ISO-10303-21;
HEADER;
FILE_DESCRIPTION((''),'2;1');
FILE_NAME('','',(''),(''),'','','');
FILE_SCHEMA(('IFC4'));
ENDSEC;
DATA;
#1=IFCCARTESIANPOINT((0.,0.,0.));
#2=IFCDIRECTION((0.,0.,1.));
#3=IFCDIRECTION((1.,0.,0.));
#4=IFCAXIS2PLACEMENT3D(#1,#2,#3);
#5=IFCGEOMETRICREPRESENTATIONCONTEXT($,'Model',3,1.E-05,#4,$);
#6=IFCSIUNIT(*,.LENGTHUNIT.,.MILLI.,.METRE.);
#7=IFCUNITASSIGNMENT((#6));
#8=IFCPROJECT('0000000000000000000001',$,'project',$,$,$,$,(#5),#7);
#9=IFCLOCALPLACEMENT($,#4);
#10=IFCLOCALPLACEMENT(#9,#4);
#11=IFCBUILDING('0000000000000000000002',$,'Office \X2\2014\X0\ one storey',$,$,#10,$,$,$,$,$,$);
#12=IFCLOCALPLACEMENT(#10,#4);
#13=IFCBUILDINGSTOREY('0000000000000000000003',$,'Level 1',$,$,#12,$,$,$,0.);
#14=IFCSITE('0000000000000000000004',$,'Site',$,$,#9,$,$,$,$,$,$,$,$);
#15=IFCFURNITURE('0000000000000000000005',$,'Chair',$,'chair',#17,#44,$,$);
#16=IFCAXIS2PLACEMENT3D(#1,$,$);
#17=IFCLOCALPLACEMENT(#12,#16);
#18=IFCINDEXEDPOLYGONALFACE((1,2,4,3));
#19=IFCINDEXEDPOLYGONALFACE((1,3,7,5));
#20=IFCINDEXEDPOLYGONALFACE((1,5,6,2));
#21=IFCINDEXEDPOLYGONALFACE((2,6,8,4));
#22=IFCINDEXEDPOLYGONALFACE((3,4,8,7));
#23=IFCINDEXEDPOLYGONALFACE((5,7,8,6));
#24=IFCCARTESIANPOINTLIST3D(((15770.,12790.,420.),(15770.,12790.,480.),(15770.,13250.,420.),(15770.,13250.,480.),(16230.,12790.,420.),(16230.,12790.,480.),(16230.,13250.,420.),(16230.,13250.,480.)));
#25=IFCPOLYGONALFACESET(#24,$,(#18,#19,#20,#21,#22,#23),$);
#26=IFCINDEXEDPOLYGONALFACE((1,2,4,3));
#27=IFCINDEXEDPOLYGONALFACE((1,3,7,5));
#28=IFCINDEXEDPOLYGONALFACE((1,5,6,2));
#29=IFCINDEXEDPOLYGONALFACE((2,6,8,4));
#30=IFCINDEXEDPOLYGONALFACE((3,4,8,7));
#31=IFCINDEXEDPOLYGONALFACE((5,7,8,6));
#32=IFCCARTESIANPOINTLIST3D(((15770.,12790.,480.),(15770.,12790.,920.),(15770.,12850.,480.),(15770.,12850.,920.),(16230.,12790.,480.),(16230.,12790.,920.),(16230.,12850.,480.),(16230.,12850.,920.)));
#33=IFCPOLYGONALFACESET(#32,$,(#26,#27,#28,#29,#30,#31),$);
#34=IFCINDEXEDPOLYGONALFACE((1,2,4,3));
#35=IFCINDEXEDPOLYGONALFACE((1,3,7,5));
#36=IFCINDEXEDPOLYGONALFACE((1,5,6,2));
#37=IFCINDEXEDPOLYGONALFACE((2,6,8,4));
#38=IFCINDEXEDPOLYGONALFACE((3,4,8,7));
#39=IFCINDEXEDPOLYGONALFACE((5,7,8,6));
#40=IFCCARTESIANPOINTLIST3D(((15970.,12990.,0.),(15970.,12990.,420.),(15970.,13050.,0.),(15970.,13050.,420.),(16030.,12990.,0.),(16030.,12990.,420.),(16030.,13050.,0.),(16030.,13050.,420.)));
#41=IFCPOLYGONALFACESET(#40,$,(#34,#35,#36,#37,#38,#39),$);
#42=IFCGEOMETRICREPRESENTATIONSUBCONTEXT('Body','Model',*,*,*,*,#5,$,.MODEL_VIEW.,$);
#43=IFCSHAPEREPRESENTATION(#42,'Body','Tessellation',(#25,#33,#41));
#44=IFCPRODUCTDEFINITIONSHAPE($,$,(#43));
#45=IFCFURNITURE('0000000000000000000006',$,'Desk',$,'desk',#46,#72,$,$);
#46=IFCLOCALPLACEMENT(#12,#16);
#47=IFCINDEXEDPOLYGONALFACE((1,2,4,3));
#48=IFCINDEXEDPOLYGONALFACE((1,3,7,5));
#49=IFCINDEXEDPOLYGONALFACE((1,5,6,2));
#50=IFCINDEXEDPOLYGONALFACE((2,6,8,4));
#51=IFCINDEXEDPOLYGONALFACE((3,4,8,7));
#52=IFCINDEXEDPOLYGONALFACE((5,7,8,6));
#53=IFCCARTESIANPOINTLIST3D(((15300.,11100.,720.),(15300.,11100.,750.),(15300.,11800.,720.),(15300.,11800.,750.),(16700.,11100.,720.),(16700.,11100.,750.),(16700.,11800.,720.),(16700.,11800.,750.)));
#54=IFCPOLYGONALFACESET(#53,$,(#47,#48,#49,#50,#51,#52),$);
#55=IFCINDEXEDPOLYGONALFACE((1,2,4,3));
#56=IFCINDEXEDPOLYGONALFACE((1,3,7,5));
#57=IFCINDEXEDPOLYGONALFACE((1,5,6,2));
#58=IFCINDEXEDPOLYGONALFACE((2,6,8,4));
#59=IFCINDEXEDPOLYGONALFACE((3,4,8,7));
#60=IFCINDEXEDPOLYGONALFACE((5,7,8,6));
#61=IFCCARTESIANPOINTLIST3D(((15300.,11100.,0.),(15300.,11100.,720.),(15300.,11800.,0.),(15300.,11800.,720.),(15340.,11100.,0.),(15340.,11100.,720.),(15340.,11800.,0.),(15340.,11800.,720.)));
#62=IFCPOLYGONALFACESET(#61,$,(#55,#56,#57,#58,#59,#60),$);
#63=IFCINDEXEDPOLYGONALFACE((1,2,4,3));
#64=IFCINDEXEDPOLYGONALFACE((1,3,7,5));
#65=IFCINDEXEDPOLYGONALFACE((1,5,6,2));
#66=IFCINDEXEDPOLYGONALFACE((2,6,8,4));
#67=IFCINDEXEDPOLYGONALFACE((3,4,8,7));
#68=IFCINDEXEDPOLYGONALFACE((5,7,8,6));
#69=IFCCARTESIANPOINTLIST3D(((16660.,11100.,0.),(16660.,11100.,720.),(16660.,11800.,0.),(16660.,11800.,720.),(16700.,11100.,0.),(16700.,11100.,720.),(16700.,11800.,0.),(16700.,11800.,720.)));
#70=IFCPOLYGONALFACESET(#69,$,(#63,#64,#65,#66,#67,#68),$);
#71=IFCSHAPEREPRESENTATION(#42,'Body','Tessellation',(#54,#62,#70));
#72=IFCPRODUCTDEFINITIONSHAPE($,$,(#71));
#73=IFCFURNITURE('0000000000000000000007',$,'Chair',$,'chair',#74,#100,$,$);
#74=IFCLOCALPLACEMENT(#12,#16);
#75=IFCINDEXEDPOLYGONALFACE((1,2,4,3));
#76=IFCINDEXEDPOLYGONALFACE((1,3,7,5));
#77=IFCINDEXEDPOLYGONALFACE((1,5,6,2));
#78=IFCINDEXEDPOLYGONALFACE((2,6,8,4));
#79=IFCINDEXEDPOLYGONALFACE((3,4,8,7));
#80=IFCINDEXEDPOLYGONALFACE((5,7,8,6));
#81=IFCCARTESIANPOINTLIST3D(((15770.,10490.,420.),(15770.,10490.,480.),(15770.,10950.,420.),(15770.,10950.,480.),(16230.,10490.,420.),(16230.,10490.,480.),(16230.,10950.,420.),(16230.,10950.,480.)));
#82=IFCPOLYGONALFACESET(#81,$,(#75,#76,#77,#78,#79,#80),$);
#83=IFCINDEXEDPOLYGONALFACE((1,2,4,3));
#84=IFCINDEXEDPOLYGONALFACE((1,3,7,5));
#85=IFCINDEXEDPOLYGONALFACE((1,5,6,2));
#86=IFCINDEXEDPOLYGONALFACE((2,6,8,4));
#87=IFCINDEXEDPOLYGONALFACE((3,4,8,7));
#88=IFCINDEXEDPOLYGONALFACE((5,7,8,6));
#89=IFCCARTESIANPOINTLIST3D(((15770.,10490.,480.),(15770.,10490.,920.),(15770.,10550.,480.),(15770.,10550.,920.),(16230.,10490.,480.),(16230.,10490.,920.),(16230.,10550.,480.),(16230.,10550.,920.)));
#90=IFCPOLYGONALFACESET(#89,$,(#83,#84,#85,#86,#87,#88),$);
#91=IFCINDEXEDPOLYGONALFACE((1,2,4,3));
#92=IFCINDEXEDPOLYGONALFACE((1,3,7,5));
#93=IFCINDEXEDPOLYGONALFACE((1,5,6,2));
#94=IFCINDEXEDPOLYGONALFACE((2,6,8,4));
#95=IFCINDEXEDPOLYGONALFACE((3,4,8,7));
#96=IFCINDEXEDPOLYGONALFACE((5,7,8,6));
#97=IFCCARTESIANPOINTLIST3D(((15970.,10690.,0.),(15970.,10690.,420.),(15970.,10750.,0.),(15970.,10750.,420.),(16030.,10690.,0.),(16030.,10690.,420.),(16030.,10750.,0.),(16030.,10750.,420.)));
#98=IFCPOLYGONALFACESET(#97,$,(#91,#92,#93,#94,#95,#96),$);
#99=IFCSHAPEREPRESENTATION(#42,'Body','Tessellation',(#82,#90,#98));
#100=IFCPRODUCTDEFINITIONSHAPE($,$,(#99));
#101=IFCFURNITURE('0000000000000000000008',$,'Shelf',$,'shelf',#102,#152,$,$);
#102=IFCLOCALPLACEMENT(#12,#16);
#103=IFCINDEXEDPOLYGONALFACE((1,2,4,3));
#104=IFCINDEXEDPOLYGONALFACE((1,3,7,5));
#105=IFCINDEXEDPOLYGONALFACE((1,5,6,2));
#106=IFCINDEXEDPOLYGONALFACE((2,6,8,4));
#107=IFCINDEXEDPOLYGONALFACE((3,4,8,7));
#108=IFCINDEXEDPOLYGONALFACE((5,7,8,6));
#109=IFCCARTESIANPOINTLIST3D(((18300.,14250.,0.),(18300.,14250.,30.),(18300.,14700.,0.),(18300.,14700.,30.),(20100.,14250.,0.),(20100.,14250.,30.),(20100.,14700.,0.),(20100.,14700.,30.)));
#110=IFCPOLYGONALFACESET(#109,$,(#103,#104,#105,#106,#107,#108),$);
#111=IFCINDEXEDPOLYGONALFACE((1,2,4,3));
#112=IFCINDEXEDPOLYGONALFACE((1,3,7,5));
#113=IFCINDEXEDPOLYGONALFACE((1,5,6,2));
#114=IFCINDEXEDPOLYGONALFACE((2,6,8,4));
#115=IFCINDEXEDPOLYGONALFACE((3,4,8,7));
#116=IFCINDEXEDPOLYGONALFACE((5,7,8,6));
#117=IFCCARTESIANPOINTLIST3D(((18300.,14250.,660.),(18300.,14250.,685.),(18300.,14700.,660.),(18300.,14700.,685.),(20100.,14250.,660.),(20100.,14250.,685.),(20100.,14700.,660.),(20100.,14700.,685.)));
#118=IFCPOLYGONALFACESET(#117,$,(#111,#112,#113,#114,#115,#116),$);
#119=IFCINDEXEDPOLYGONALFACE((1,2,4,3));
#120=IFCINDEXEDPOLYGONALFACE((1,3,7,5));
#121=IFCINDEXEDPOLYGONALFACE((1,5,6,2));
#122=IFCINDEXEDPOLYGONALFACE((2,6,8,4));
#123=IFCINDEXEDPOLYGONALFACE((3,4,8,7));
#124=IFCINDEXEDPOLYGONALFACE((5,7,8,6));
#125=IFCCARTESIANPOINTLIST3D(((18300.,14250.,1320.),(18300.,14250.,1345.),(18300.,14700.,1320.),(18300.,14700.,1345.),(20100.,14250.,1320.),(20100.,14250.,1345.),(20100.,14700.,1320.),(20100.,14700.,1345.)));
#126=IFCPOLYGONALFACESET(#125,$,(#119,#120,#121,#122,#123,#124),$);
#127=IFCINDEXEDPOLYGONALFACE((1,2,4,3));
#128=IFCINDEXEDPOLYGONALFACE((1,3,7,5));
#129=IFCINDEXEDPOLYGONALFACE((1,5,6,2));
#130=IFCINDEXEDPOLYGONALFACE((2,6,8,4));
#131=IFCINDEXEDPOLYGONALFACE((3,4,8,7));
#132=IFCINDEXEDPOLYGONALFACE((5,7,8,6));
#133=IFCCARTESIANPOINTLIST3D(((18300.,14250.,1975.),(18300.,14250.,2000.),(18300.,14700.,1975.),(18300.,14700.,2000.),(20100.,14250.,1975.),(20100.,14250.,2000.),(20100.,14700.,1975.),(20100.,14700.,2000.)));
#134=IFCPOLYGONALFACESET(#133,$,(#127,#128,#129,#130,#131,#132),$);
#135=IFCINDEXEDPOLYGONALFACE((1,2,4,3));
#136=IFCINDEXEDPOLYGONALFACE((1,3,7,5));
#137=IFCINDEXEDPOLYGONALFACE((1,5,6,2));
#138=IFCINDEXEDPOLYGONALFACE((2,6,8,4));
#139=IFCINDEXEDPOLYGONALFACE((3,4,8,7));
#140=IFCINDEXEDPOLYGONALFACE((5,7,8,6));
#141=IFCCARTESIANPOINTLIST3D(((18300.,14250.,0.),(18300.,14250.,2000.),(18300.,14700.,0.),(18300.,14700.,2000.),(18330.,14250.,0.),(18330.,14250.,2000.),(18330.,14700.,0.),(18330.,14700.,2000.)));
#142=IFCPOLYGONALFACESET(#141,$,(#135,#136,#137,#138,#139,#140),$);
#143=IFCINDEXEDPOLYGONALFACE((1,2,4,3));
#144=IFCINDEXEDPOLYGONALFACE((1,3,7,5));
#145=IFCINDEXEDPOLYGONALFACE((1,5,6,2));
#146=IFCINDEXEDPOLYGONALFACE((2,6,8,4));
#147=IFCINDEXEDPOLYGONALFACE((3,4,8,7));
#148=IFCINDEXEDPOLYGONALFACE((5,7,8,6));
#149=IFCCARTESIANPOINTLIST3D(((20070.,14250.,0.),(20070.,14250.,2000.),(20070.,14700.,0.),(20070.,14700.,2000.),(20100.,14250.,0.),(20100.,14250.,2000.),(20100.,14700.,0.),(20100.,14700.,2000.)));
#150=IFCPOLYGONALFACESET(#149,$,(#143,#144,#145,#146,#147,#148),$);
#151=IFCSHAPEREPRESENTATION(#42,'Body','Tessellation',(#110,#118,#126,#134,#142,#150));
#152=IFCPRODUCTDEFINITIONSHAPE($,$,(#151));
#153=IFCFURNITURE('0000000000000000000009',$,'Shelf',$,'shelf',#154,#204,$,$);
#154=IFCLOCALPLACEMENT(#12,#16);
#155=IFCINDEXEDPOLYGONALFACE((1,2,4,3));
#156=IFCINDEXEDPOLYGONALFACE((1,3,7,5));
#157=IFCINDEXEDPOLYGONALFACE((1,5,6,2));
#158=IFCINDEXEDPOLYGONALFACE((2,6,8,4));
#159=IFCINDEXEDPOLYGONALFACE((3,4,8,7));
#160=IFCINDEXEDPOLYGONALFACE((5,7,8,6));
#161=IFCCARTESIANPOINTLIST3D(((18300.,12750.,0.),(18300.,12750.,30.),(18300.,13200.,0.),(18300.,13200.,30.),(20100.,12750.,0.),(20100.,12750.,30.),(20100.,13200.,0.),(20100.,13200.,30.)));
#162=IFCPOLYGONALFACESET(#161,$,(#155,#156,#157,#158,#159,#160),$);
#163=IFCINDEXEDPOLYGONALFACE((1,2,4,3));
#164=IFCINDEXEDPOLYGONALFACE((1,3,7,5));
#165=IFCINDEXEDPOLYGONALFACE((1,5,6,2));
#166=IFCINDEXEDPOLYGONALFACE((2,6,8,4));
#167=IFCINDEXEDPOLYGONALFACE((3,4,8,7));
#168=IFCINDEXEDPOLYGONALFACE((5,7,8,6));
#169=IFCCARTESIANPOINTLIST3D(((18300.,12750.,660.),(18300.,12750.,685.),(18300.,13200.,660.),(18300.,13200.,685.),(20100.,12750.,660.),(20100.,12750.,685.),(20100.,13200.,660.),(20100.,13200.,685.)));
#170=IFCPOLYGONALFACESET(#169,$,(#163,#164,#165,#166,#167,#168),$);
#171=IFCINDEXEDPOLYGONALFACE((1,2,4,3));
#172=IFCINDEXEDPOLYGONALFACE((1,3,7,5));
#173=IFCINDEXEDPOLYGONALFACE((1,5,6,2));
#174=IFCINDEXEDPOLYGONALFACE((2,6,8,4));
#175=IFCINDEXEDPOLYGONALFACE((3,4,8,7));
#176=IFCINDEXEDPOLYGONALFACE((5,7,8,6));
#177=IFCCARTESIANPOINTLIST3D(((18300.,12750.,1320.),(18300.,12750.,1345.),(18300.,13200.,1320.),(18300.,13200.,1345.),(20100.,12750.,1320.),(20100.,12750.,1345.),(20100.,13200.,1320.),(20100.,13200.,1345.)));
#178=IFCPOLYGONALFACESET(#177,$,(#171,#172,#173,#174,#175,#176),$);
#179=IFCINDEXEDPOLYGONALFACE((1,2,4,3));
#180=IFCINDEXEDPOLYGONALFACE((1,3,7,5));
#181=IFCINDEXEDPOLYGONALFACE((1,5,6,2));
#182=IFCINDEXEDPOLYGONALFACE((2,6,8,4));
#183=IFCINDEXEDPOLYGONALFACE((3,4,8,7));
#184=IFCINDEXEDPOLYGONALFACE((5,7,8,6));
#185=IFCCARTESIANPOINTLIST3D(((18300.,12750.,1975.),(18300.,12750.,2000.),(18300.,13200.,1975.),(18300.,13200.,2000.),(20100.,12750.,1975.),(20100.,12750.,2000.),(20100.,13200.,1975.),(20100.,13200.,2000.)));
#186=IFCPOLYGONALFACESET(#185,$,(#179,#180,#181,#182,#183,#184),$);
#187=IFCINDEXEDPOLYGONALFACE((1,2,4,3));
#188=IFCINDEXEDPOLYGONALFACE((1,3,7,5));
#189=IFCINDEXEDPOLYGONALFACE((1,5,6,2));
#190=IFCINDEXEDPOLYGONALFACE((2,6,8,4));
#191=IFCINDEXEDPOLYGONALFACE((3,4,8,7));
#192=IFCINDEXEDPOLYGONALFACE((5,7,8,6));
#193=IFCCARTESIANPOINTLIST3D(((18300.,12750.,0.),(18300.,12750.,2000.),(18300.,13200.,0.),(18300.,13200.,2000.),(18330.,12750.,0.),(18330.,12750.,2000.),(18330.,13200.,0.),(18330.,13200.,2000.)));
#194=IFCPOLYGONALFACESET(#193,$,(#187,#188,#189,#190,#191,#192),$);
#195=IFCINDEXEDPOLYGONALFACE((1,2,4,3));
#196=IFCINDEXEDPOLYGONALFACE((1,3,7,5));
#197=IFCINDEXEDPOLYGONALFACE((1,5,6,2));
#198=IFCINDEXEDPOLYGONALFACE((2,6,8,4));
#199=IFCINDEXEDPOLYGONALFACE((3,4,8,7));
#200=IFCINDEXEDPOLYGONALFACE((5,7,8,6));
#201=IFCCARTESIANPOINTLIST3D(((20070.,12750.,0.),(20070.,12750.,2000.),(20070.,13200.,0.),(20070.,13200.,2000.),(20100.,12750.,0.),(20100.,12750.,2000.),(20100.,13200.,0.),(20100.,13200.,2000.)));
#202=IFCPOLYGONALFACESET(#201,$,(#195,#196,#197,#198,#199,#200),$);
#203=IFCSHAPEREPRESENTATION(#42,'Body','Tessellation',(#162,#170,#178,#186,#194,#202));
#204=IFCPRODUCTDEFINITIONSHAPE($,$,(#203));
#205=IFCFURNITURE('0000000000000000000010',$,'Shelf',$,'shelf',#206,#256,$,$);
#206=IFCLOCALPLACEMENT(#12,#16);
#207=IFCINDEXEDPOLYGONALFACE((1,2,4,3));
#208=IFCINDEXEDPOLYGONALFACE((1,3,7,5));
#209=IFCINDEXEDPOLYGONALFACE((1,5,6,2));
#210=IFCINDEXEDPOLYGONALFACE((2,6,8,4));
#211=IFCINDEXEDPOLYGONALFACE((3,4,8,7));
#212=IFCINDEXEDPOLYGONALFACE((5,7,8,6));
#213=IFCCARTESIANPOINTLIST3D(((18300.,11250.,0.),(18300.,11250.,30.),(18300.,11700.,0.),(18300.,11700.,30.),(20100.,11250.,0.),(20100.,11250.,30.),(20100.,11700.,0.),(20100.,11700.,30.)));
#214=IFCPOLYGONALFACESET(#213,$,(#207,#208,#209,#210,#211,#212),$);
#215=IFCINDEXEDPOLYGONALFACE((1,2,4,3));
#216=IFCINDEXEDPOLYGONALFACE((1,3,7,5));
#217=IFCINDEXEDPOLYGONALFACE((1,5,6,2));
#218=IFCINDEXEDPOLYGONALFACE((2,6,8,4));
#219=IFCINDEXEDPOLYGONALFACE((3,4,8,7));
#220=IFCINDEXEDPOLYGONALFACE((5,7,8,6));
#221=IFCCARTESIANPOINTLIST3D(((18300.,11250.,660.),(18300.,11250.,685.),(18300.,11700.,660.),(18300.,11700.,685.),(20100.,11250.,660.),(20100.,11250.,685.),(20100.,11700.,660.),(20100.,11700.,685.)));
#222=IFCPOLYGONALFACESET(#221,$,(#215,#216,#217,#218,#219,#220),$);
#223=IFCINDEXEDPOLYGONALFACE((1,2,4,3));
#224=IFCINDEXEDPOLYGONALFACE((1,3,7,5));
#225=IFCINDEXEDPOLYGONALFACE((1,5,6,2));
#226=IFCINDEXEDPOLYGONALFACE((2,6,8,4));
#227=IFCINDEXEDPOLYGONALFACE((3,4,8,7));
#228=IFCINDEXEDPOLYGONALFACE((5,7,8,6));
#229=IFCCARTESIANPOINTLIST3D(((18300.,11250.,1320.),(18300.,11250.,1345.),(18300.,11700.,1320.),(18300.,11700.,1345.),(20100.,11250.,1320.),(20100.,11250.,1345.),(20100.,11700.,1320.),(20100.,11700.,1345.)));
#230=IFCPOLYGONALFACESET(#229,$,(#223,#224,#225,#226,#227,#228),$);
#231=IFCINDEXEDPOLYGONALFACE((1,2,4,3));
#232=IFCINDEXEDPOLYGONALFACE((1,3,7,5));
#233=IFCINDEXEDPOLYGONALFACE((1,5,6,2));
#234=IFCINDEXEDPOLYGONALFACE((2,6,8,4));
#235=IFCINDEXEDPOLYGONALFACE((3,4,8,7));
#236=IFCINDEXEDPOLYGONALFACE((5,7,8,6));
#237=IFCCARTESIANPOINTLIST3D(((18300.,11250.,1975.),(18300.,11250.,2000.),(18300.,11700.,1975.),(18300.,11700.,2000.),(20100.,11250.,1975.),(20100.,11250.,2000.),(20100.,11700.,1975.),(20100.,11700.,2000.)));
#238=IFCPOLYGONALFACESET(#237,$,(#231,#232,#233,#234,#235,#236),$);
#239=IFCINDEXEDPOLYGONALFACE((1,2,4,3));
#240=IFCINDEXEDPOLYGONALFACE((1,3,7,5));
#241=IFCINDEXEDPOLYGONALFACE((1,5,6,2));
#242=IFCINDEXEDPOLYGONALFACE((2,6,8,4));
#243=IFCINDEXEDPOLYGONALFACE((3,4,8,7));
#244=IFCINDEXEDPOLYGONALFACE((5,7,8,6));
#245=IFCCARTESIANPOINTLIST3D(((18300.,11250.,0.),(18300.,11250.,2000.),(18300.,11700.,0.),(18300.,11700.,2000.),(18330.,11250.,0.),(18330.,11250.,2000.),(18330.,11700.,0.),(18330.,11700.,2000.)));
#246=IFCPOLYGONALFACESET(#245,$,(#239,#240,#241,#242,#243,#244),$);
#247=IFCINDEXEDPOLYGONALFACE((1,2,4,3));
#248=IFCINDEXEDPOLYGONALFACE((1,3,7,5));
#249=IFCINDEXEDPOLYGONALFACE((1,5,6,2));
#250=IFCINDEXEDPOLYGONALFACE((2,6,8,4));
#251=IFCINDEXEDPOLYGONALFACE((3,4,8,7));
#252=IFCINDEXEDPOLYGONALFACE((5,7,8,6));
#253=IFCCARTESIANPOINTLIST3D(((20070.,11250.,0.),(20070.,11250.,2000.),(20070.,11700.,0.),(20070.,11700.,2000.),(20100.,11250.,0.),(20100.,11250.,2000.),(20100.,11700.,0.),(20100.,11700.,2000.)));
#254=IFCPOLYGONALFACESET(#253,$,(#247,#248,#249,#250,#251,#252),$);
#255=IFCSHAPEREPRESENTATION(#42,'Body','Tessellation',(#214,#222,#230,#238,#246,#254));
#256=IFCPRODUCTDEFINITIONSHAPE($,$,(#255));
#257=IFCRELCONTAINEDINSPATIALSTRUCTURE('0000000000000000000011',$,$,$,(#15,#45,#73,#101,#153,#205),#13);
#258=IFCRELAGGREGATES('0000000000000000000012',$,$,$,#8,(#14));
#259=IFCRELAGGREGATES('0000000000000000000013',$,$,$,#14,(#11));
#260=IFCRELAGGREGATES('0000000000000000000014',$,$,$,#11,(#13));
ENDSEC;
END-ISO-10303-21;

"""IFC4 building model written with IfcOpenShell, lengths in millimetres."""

from ifc_helpers import new_model, si_unit, frame, frame_2d, origin, origin_with_axes, place, context, subcontext, project, spatial, rectangle, extrude, element, save


model = new_model("IFC4")

# Units and contexts
model_context = context("Model", 3, precision=1e-05, world=origin_with_axes())
body_context = subcontext(model_context, "Body", "Model", "MODEL_VIEW")
ifc_project = project(units=[si_unit("LENGTHUNIT", "METRE", prefix="MILLI")], contexts=[model_context])

# Site, building, storey
site_placement = place(None, origin_with_axes())
site = spatial("IfcSite", under=ifc_project, at=site_placement, Name="Site")
building_placement = place(site_placement, origin_with_axes())
building = spatial("IfcBuilding", under=site, at=building_placement, Name="Office — one storey")
storey_placement = place(building_placement, origin_with_axes())
storey = spatial("IfcBuildingStorey", under=building, at=storey_placement, Name="Level 1", Elevation=0.0)

# Furniture
furniture_1_placement = place(storey_placement, frame((15770.0, 12790.0, 0.0), z_axis=(0.0, 0.0, 1.0), x_axis=(1.0, 0.0, 0.0)))
element("IfcFurniture", 1, at=furniture_1_placement, inside=storey, Name="Chair", ObjectType="chair", context=body_context, shape_type="SweptSolid", body=[
    extrude(rectangle(XDim=460.0, YDim=460.0, at=frame_2d((230.0, 230.0))), frame((0.0, 0.0, 420.0)), (0.0, 0.0, 1.0), 60.0),
    extrude(rectangle(XDim=460.0, YDim=60.0, at=frame_2d((230.0, 30.0))), frame((0.0, 0.0, 480.0)), (0.0, 0.0, 1.0), 440.0),
    extrude(rectangle(XDim=60.0, YDim=60.0, at=frame_2d((230.0, 230.0))), origin(), (0.0, 0.0, 1.0), 420.0),
])
furniture_2_placement = place(storey_placement, frame((15300.0, 11100.0, 0.0), z_axis=(0.0, 0.0, 1.0), x_axis=(1.0, 0.0, 0.0)))
element("IfcFurniture", 2, at=furniture_2_placement, inside=storey, Name="Desk", ObjectType="desk", context=body_context, shape_type="SweptSolid", body=[
    extrude(rectangle(XDim=1400.0, YDim=700.0, at=frame_2d((700.0, 350.0))), frame((0.0, 0.0, 720.0)), (0.0, 0.0, 1.0), 30.0),
    extrude(rectangle(XDim=40.0, YDim=700.0, at=frame_2d((20.0, 350.0))), origin(), (0.0, 0.0, 1.0), 720.0),
    extrude(rectangle(XDim=40.0, YDim=700.0, at=frame_2d((1380.0, 350.0))), origin(), (0.0, 0.0, 1.0), 720.0),
])
furniture_3_placement = place(storey_placement, frame((15770.0, 10490.0, 0.0), z_axis=(0.0, 0.0, 1.0), x_axis=(1.0, 0.0, 0.0)))
element("IfcFurniture", 3, at=furniture_3_placement, inside=storey, Name="Chair", ObjectType="chair", context=body_context, shape_type="SweptSolid", body=[
    extrude(rectangle(XDim=460.0, YDim=460.0, at=frame_2d((230.0, 230.0))), frame((0.0, 0.0, 420.0)), (0.0, 0.0, 1.0), 60.0),
    extrude(rectangle(XDim=460.0, YDim=60.0, at=frame_2d((230.0, 30.0))), frame((0.0, 0.0, 480.0)), (0.0, 0.0, 1.0), 440.0),
    extrude(rectangle(XDim=60.0, YDim=60.0, at=frame_2d((230.0, 230.0))), origin(), (0.0, 0.0, 1.0), 420.0),
])
for number, where, z_axis, x_axis, name in (
    (4, (18300.0, 14250.0, 0.0), (0.0, 0.0, 1.0), (1.0, 0.0, 0.0), "Shelf"),
    (5, (18300.0, 12750.0, 0.0), (0.0, 0.0, 1.0), (1.0, 0.0, 0.0), "Shelf"),
    (6, (18300.0, 11250.0, 0.0), (0.0, 0.0, 1.0), (1.0, 0.0, 0.0), "Shelf"),
):
    element("IfcFurniture", number, at=place(storey_placement, frame(where, z_axis=z_axis, x_axis=x_axis)), inside=storey, Name=name, ObjectType="shelf", context=body_context, shape_type="SweptSolid", body=[
        extrude(rectangle(XDim=1800.0, YDim=450.0, at=frame_2d((900.0, 225.0))), origin(), (0.0, 0.0, 1.0), 30.0),
        extrude(rectangle(XDim=1800.0, YDim=450.0, at=frame_2d((900.0, 225.0))), frame((0.0, 0.0, 660.0)), (0.0, 0.0, 1.0), 25.0),
        extrude(rectangle(XDim=1800.0, YDim=450.0, at=frame_2d((900.0, 225.0))), frame((0.0, 0.0, 1320.0)), (0.0, 0.0, 1.0), 25.0),
        extrude(rectangle(XDim=1800.0, YDim=450.0, at=frame_2d((900.0, 225.0))), frame((0.0, 0.0, 1975.0)), (0.0, 0.0, 1.0), 25.0),
        extrude(rectangle(XDim=30.0, YDim=450.0, at=frame_2d((15.0, 225.0))), origin(), (0.0, 0.0, 1.0), 2000.0),
        extrude(rectangle(XDim=30.0, YDim=450.0, at=frame_2d((1785.0, 225.0))), origin(), (0.0, 0.0, 1.0), 2000.0),
    ])

save(model, "model.ifc")
